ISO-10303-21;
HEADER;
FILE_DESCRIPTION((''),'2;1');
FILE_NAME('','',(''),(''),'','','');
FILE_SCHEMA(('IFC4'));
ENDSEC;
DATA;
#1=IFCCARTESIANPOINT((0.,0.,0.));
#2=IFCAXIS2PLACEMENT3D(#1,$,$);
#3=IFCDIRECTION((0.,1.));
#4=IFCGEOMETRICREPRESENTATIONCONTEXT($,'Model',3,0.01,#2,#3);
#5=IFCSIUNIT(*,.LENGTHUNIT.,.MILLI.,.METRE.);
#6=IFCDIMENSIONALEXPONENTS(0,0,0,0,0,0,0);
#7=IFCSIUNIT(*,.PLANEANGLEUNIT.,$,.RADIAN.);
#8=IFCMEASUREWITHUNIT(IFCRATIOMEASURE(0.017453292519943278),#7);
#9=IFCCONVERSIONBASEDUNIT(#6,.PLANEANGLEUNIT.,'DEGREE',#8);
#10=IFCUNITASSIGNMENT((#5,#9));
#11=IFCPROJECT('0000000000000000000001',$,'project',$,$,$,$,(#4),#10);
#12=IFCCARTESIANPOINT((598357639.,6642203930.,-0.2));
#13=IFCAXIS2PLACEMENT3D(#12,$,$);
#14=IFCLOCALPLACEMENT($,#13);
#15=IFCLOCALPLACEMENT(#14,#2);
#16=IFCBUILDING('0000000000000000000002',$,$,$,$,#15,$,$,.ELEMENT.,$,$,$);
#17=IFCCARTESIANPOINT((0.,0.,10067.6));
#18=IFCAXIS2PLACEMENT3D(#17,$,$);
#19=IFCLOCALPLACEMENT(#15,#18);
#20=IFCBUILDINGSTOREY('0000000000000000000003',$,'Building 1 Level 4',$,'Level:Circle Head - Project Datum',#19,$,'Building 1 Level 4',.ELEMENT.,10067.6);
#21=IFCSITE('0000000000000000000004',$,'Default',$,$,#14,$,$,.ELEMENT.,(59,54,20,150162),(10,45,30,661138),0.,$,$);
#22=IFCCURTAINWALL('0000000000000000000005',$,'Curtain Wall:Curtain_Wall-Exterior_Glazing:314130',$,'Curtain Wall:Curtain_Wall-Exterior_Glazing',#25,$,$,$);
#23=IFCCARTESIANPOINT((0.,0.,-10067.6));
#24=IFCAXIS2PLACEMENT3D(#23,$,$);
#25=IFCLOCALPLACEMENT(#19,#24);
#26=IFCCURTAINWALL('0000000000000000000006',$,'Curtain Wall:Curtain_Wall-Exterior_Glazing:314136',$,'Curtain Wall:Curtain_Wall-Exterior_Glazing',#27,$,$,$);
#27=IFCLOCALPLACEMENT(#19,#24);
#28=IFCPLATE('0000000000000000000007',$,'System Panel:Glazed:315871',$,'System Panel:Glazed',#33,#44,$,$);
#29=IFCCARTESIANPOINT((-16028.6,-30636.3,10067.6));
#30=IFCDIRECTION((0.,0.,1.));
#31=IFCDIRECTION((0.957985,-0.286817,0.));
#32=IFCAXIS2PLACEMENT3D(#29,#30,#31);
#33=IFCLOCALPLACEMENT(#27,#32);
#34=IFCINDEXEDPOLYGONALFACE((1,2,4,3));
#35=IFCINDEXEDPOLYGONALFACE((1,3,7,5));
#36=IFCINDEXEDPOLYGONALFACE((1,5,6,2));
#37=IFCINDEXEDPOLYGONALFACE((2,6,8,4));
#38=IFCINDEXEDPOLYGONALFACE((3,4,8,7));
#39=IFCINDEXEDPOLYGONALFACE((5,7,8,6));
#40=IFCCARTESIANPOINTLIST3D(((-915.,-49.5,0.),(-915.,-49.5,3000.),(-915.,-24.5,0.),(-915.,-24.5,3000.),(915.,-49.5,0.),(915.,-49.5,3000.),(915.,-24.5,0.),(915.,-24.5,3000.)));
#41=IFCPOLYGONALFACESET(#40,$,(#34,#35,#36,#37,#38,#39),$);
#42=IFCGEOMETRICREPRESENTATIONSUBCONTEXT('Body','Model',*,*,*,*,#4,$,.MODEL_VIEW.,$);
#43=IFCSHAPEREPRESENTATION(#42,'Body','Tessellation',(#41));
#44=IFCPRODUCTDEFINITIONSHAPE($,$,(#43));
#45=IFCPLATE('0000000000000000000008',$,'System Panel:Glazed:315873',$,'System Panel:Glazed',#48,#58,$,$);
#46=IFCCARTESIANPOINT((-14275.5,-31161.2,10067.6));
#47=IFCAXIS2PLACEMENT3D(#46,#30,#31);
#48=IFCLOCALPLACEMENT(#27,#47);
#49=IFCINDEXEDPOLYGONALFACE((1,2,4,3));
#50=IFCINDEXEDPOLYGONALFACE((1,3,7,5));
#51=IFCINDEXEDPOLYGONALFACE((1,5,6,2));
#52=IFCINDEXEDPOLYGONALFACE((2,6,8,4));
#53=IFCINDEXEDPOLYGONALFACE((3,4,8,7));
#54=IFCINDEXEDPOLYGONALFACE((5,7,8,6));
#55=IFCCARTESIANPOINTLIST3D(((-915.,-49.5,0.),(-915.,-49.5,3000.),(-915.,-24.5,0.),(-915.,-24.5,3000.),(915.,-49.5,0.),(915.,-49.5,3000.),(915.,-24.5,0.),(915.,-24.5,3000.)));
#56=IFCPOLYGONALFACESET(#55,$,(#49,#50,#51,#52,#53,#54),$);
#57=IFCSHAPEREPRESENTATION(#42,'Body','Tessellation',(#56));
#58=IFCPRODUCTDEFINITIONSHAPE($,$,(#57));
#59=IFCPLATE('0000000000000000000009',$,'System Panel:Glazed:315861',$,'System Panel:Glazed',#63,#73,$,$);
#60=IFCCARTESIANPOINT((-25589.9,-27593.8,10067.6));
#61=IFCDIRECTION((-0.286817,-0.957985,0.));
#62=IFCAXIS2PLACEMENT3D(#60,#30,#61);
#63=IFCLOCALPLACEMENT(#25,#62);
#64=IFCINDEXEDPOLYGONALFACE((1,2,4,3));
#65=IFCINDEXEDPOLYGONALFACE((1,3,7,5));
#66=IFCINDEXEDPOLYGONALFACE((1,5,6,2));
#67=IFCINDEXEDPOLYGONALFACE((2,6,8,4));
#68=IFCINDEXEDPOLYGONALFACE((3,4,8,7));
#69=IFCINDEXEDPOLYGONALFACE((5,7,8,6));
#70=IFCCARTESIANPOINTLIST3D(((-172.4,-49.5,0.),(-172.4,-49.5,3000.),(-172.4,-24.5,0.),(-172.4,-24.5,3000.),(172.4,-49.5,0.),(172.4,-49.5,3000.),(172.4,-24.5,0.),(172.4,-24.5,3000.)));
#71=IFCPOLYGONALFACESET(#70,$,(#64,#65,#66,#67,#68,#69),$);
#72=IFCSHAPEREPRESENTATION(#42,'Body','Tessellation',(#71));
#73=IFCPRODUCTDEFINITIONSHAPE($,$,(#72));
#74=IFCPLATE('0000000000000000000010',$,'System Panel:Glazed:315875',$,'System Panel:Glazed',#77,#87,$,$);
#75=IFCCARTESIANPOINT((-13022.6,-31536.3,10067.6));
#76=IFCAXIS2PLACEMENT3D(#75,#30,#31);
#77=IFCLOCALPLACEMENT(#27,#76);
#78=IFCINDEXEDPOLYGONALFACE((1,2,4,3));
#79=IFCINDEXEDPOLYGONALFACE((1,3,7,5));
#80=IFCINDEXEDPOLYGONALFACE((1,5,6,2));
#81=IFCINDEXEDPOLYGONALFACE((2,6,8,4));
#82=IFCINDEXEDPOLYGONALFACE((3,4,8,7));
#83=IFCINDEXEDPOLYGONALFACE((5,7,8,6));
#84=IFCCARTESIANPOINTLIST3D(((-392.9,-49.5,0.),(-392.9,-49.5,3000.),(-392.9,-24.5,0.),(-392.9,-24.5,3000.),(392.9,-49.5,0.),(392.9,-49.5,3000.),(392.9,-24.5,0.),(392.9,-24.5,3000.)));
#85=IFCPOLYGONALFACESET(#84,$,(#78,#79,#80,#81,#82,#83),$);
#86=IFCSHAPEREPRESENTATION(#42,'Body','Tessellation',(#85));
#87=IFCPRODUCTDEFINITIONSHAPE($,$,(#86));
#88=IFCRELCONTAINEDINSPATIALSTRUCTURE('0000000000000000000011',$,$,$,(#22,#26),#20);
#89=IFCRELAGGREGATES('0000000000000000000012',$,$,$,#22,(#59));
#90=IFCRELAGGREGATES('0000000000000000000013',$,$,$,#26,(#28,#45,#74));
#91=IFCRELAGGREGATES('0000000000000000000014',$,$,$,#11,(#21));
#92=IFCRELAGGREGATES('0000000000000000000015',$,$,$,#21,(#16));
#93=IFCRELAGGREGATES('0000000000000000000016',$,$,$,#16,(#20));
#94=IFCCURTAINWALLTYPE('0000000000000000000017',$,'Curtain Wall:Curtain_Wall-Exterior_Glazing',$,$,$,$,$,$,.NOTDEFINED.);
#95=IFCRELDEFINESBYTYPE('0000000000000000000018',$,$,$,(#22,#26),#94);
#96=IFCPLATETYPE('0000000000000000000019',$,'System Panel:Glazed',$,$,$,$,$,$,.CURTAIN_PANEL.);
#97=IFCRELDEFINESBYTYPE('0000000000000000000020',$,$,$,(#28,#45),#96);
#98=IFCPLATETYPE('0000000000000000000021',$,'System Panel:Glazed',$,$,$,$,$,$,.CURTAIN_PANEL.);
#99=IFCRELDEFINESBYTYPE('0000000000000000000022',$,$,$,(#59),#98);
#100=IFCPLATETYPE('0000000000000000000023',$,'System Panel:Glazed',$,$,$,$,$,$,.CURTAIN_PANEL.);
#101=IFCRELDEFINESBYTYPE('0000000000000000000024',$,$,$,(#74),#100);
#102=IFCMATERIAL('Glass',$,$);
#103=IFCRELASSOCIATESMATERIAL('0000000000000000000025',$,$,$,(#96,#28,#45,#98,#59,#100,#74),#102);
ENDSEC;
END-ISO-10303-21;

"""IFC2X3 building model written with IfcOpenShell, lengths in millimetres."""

from ifc_helpers import new_model, entity, si_unit, converted_unit, direction, frame, frame_2d, origin, place, context, subcontext, project, spatial, rectangle, extrude, source, transform, mapped, material, type_object, type_shapes, element, aggregate, save


model = new_model("IFC2X3")

# Units and contexts
model_context = context("Model", 3, precision=0.01, world=origin(), true_north=direction((0.0, 1.0)))
body_context = subcontext(model_context, "Body", "Model", "MODEL_VIEW")
ifc_project = project(units=[si_unit("LENGTHUNIT", "METRE", prefix="MILLI"), converted_unit("PLANEANGLEUNIT", "DEGREE", entity("IfcRatioMeasure", 0.017453292519943278), si_unit("PLANEANGLEUNIT", "RADIAN"), dimensions=[0, 0, 0, 0, 0, 0, 0])], contexts=[model_context])

# Site, building, storey
site_placement = place(None, frame((598357639.0, 6642203930.0, -0.2)))
site = spatial("IfcSite", under=ifc_project, at=site_placement, Name="Default", CompositionType="ELEMENT", RefLatitude=(59, 54, 20, 150162), RefLongitude=(10, 45, 30, 661138), RefElevation=0.0)
building_placement = place(site_placement, origin())
building = spatial("IfcBuilding", under=site, at=building_placement, CompositionType="ELEMENT")
storey_placement = place(building_placement, frame((0.0, 0.0, 10067.6)))
storey = spatial("IfcBuildingStorey", under=building, at=storey_placement, Name="Building 1 Level 4", ObjectType="Level:Circle Head - Project Datum", LongName="Building 1 Level 4", CompositionType="ELEMENT", Elevation=10067.6)

# Curtain walls, plates
curtain_wall_type = type_object("IfcCurtainWallType", Name="Curtain Wall:Curtain_Wall-Exterior_Glazing", PredefinedType="NOTDEFINED")
curtain_wall_1_placement = place(storey_placement, frame((0.0, 0.0, -10067.6)))
curtain_wall_1 = element("IfcCurtainWall", 1, at=curtain_wall_1_placement, inside=storey, type_object=curtain_wall_type, Name="Curtain Wall:Curtain_Wall-Exterior_Glazing:314130", ObjectType="Curtain Wall:Curtain_Wall-Exterior_Glazing")
ifc_material_1 = material(Name="Glass")
plate_type_1 = type_object("IfcPlateType", Name="System Panel:Glazed", PredefinedType="CURTAIN_PANEL", material=ifc_material_1)
shared_shape_1 = source(origin(), body_context, "Body", "SweptSolid", [
    extrude(rectangle(XDim=25.0, YDim=1830.0, at=frame_2d((0.0, 0.0), x_axis=(1.0, 0.0))), frame((0.0, -37.0, 0.0), z_axis=(0.0, 0.0, 1.0), x_axis=(0.0, 1.0, 0.0)), (0.0, 0.0, 1.0), 3000.0),
])
type_shapes(plate_type_1, [shared_shape_1])
curtain_wall_2_placement = place(storey_placement, frame((0.0, 0.0, -10067.6)))
curtain_wall_2 = element("IfcCurtainWall", 2, at=curtain_wall_2_placement, inside=storey, type_object=curtain_wall_type, Name="Curtain Wall:Curtain_Wall-Exterior_Glazing:314136", ObjectType="Curtain Wall:Curtain_Wall-Exterior_Glazing")
plate_1_placement = place(curtain_wall_2_placement, frame((-16028.6, -30636.3, 10067.6), z_axis=(0.0, 0.0, 1.0), x_axis=(0.957985, -0.286817, 0.0)))
plate_1 = element("IfcPlate", 3, at=plate_1_placement, type_object=plate_type_1, material=ifc_material_1, Name="System Panel:Glazed:315871", ObjectType="System Panel:Glazed", context=body_context, shape_type="MappedRepresentation", body=[
    mapped(shared_shape_1, transform((0.0, 0.0, 0.0), scale=1.0)),
])
plate_2_placement = place(curtain_wall_2_placement, frame((-14275.5, -31161.2, 10067.6), z_axis=(0.0, 0.0, 1.0), x_axis=(0.957985, -0.286817, 0.0)))
plate_2 = element("IfcPlate", 4, at=plate_2_placement, type_object=plate_type_1, material=ifc_material_1, Name="System Panel:Glazed:315873", ObjectType="System Panel:Glazed", context=body_context, shape_type="MappedRepresentation", body=[
    mapped(shared_shape_1, transform((0.0, 0.0, 0.0), scale=1.0)),
])

# Plates
plate_type_2 = type_object("IfcPlateType", Name="System Panel:Glazed", PredefinedType="CURTAIN_PANEL", material=ifc_material_1)
shared_shape_2 = source(origin(), body_context, "Body", "SweptSolid", [
    extrude(rectangle(XDim=25.0, YDim=344.8, at=frame_2d((0.0, 0.0), x_axis=(1.0, 0.0))), frame((0.0, -37.0, 0.0), z_axis=(0.0, 0.0, 1.0), x_axis=(0.0, 1.0, 0.0)), (0.0, 0.0, 1.0), 3000.0),
])
type_shapes(plate_type_2, [shared_shape_2])
plate_3_placement = place(curtain_wall_1_placement, frame((-25589.9, -27593.8, 10067.6), z_axis=(0.0, 0.0, 1.0), x_axis=(-0.286817, -0.957985, 0.0)))
plate_3 = element("IfcPlate", 5, at=plate_3_placement, type_object=plate_type_2, material=ifc_material_1, Name="System Panel:Glazed:315861", ObjectType="System Panel:Glazed", context=body_context, shape_type="MappedRepresentation", body=[
    mapped(shared_shape_2, transform((0.0, 0.0, 0.0), scale=1.0)),
])
aggregate(curtain_wall_1, [plate_3])
plate_type_3 = type_object("IfcPlateType", Name="System Panel:Glazed", PredefinedType="CURTAIN_PANEL", material=ifc_material_1)
shared_shape_3 = source(origin(), body_context, "Body", "SweptSolid", [
    extrude(rectangle(XDim=25.0, YDim=785.7, at=frame_2d((0.0, 0.0), x_axis=(1.0, 0.0))), frame((0.0, -37.0, 0.0), z_axis=(0.0, 0.0, 1.0), x_axis=(0.0, 1.0, 0.0)), (0.0, 0.0, 1.0), 3000.0),
])
type_shapes(plate_type_3, [shared_shape_3])
plate_4_placement = place(curtain_wall_2_placement, frame((-13022.6, -31536.3, 10067.6), z_axis=(0.0, 0.0, 1.0), x_axis=(0.957985, -0.286817, 0.0)))
plate_4 = element("IfcPlate", 6, at=plate_4_placement, type_object=plate_type_3, material=ifc_material_1, Name="System Panel:Glazed:315875", ObjectType="System Panel:Glazed", context=body_context, shape_type="MappedRepresentation", body=[
    mapped(shared_shape_3, transform((0.0, 0.0, 0.0), scale=1.0)),
])
aggregate(curtain_wall_2, [plate_1, plate_2, plate_4])

save(model, "model.ifc")
